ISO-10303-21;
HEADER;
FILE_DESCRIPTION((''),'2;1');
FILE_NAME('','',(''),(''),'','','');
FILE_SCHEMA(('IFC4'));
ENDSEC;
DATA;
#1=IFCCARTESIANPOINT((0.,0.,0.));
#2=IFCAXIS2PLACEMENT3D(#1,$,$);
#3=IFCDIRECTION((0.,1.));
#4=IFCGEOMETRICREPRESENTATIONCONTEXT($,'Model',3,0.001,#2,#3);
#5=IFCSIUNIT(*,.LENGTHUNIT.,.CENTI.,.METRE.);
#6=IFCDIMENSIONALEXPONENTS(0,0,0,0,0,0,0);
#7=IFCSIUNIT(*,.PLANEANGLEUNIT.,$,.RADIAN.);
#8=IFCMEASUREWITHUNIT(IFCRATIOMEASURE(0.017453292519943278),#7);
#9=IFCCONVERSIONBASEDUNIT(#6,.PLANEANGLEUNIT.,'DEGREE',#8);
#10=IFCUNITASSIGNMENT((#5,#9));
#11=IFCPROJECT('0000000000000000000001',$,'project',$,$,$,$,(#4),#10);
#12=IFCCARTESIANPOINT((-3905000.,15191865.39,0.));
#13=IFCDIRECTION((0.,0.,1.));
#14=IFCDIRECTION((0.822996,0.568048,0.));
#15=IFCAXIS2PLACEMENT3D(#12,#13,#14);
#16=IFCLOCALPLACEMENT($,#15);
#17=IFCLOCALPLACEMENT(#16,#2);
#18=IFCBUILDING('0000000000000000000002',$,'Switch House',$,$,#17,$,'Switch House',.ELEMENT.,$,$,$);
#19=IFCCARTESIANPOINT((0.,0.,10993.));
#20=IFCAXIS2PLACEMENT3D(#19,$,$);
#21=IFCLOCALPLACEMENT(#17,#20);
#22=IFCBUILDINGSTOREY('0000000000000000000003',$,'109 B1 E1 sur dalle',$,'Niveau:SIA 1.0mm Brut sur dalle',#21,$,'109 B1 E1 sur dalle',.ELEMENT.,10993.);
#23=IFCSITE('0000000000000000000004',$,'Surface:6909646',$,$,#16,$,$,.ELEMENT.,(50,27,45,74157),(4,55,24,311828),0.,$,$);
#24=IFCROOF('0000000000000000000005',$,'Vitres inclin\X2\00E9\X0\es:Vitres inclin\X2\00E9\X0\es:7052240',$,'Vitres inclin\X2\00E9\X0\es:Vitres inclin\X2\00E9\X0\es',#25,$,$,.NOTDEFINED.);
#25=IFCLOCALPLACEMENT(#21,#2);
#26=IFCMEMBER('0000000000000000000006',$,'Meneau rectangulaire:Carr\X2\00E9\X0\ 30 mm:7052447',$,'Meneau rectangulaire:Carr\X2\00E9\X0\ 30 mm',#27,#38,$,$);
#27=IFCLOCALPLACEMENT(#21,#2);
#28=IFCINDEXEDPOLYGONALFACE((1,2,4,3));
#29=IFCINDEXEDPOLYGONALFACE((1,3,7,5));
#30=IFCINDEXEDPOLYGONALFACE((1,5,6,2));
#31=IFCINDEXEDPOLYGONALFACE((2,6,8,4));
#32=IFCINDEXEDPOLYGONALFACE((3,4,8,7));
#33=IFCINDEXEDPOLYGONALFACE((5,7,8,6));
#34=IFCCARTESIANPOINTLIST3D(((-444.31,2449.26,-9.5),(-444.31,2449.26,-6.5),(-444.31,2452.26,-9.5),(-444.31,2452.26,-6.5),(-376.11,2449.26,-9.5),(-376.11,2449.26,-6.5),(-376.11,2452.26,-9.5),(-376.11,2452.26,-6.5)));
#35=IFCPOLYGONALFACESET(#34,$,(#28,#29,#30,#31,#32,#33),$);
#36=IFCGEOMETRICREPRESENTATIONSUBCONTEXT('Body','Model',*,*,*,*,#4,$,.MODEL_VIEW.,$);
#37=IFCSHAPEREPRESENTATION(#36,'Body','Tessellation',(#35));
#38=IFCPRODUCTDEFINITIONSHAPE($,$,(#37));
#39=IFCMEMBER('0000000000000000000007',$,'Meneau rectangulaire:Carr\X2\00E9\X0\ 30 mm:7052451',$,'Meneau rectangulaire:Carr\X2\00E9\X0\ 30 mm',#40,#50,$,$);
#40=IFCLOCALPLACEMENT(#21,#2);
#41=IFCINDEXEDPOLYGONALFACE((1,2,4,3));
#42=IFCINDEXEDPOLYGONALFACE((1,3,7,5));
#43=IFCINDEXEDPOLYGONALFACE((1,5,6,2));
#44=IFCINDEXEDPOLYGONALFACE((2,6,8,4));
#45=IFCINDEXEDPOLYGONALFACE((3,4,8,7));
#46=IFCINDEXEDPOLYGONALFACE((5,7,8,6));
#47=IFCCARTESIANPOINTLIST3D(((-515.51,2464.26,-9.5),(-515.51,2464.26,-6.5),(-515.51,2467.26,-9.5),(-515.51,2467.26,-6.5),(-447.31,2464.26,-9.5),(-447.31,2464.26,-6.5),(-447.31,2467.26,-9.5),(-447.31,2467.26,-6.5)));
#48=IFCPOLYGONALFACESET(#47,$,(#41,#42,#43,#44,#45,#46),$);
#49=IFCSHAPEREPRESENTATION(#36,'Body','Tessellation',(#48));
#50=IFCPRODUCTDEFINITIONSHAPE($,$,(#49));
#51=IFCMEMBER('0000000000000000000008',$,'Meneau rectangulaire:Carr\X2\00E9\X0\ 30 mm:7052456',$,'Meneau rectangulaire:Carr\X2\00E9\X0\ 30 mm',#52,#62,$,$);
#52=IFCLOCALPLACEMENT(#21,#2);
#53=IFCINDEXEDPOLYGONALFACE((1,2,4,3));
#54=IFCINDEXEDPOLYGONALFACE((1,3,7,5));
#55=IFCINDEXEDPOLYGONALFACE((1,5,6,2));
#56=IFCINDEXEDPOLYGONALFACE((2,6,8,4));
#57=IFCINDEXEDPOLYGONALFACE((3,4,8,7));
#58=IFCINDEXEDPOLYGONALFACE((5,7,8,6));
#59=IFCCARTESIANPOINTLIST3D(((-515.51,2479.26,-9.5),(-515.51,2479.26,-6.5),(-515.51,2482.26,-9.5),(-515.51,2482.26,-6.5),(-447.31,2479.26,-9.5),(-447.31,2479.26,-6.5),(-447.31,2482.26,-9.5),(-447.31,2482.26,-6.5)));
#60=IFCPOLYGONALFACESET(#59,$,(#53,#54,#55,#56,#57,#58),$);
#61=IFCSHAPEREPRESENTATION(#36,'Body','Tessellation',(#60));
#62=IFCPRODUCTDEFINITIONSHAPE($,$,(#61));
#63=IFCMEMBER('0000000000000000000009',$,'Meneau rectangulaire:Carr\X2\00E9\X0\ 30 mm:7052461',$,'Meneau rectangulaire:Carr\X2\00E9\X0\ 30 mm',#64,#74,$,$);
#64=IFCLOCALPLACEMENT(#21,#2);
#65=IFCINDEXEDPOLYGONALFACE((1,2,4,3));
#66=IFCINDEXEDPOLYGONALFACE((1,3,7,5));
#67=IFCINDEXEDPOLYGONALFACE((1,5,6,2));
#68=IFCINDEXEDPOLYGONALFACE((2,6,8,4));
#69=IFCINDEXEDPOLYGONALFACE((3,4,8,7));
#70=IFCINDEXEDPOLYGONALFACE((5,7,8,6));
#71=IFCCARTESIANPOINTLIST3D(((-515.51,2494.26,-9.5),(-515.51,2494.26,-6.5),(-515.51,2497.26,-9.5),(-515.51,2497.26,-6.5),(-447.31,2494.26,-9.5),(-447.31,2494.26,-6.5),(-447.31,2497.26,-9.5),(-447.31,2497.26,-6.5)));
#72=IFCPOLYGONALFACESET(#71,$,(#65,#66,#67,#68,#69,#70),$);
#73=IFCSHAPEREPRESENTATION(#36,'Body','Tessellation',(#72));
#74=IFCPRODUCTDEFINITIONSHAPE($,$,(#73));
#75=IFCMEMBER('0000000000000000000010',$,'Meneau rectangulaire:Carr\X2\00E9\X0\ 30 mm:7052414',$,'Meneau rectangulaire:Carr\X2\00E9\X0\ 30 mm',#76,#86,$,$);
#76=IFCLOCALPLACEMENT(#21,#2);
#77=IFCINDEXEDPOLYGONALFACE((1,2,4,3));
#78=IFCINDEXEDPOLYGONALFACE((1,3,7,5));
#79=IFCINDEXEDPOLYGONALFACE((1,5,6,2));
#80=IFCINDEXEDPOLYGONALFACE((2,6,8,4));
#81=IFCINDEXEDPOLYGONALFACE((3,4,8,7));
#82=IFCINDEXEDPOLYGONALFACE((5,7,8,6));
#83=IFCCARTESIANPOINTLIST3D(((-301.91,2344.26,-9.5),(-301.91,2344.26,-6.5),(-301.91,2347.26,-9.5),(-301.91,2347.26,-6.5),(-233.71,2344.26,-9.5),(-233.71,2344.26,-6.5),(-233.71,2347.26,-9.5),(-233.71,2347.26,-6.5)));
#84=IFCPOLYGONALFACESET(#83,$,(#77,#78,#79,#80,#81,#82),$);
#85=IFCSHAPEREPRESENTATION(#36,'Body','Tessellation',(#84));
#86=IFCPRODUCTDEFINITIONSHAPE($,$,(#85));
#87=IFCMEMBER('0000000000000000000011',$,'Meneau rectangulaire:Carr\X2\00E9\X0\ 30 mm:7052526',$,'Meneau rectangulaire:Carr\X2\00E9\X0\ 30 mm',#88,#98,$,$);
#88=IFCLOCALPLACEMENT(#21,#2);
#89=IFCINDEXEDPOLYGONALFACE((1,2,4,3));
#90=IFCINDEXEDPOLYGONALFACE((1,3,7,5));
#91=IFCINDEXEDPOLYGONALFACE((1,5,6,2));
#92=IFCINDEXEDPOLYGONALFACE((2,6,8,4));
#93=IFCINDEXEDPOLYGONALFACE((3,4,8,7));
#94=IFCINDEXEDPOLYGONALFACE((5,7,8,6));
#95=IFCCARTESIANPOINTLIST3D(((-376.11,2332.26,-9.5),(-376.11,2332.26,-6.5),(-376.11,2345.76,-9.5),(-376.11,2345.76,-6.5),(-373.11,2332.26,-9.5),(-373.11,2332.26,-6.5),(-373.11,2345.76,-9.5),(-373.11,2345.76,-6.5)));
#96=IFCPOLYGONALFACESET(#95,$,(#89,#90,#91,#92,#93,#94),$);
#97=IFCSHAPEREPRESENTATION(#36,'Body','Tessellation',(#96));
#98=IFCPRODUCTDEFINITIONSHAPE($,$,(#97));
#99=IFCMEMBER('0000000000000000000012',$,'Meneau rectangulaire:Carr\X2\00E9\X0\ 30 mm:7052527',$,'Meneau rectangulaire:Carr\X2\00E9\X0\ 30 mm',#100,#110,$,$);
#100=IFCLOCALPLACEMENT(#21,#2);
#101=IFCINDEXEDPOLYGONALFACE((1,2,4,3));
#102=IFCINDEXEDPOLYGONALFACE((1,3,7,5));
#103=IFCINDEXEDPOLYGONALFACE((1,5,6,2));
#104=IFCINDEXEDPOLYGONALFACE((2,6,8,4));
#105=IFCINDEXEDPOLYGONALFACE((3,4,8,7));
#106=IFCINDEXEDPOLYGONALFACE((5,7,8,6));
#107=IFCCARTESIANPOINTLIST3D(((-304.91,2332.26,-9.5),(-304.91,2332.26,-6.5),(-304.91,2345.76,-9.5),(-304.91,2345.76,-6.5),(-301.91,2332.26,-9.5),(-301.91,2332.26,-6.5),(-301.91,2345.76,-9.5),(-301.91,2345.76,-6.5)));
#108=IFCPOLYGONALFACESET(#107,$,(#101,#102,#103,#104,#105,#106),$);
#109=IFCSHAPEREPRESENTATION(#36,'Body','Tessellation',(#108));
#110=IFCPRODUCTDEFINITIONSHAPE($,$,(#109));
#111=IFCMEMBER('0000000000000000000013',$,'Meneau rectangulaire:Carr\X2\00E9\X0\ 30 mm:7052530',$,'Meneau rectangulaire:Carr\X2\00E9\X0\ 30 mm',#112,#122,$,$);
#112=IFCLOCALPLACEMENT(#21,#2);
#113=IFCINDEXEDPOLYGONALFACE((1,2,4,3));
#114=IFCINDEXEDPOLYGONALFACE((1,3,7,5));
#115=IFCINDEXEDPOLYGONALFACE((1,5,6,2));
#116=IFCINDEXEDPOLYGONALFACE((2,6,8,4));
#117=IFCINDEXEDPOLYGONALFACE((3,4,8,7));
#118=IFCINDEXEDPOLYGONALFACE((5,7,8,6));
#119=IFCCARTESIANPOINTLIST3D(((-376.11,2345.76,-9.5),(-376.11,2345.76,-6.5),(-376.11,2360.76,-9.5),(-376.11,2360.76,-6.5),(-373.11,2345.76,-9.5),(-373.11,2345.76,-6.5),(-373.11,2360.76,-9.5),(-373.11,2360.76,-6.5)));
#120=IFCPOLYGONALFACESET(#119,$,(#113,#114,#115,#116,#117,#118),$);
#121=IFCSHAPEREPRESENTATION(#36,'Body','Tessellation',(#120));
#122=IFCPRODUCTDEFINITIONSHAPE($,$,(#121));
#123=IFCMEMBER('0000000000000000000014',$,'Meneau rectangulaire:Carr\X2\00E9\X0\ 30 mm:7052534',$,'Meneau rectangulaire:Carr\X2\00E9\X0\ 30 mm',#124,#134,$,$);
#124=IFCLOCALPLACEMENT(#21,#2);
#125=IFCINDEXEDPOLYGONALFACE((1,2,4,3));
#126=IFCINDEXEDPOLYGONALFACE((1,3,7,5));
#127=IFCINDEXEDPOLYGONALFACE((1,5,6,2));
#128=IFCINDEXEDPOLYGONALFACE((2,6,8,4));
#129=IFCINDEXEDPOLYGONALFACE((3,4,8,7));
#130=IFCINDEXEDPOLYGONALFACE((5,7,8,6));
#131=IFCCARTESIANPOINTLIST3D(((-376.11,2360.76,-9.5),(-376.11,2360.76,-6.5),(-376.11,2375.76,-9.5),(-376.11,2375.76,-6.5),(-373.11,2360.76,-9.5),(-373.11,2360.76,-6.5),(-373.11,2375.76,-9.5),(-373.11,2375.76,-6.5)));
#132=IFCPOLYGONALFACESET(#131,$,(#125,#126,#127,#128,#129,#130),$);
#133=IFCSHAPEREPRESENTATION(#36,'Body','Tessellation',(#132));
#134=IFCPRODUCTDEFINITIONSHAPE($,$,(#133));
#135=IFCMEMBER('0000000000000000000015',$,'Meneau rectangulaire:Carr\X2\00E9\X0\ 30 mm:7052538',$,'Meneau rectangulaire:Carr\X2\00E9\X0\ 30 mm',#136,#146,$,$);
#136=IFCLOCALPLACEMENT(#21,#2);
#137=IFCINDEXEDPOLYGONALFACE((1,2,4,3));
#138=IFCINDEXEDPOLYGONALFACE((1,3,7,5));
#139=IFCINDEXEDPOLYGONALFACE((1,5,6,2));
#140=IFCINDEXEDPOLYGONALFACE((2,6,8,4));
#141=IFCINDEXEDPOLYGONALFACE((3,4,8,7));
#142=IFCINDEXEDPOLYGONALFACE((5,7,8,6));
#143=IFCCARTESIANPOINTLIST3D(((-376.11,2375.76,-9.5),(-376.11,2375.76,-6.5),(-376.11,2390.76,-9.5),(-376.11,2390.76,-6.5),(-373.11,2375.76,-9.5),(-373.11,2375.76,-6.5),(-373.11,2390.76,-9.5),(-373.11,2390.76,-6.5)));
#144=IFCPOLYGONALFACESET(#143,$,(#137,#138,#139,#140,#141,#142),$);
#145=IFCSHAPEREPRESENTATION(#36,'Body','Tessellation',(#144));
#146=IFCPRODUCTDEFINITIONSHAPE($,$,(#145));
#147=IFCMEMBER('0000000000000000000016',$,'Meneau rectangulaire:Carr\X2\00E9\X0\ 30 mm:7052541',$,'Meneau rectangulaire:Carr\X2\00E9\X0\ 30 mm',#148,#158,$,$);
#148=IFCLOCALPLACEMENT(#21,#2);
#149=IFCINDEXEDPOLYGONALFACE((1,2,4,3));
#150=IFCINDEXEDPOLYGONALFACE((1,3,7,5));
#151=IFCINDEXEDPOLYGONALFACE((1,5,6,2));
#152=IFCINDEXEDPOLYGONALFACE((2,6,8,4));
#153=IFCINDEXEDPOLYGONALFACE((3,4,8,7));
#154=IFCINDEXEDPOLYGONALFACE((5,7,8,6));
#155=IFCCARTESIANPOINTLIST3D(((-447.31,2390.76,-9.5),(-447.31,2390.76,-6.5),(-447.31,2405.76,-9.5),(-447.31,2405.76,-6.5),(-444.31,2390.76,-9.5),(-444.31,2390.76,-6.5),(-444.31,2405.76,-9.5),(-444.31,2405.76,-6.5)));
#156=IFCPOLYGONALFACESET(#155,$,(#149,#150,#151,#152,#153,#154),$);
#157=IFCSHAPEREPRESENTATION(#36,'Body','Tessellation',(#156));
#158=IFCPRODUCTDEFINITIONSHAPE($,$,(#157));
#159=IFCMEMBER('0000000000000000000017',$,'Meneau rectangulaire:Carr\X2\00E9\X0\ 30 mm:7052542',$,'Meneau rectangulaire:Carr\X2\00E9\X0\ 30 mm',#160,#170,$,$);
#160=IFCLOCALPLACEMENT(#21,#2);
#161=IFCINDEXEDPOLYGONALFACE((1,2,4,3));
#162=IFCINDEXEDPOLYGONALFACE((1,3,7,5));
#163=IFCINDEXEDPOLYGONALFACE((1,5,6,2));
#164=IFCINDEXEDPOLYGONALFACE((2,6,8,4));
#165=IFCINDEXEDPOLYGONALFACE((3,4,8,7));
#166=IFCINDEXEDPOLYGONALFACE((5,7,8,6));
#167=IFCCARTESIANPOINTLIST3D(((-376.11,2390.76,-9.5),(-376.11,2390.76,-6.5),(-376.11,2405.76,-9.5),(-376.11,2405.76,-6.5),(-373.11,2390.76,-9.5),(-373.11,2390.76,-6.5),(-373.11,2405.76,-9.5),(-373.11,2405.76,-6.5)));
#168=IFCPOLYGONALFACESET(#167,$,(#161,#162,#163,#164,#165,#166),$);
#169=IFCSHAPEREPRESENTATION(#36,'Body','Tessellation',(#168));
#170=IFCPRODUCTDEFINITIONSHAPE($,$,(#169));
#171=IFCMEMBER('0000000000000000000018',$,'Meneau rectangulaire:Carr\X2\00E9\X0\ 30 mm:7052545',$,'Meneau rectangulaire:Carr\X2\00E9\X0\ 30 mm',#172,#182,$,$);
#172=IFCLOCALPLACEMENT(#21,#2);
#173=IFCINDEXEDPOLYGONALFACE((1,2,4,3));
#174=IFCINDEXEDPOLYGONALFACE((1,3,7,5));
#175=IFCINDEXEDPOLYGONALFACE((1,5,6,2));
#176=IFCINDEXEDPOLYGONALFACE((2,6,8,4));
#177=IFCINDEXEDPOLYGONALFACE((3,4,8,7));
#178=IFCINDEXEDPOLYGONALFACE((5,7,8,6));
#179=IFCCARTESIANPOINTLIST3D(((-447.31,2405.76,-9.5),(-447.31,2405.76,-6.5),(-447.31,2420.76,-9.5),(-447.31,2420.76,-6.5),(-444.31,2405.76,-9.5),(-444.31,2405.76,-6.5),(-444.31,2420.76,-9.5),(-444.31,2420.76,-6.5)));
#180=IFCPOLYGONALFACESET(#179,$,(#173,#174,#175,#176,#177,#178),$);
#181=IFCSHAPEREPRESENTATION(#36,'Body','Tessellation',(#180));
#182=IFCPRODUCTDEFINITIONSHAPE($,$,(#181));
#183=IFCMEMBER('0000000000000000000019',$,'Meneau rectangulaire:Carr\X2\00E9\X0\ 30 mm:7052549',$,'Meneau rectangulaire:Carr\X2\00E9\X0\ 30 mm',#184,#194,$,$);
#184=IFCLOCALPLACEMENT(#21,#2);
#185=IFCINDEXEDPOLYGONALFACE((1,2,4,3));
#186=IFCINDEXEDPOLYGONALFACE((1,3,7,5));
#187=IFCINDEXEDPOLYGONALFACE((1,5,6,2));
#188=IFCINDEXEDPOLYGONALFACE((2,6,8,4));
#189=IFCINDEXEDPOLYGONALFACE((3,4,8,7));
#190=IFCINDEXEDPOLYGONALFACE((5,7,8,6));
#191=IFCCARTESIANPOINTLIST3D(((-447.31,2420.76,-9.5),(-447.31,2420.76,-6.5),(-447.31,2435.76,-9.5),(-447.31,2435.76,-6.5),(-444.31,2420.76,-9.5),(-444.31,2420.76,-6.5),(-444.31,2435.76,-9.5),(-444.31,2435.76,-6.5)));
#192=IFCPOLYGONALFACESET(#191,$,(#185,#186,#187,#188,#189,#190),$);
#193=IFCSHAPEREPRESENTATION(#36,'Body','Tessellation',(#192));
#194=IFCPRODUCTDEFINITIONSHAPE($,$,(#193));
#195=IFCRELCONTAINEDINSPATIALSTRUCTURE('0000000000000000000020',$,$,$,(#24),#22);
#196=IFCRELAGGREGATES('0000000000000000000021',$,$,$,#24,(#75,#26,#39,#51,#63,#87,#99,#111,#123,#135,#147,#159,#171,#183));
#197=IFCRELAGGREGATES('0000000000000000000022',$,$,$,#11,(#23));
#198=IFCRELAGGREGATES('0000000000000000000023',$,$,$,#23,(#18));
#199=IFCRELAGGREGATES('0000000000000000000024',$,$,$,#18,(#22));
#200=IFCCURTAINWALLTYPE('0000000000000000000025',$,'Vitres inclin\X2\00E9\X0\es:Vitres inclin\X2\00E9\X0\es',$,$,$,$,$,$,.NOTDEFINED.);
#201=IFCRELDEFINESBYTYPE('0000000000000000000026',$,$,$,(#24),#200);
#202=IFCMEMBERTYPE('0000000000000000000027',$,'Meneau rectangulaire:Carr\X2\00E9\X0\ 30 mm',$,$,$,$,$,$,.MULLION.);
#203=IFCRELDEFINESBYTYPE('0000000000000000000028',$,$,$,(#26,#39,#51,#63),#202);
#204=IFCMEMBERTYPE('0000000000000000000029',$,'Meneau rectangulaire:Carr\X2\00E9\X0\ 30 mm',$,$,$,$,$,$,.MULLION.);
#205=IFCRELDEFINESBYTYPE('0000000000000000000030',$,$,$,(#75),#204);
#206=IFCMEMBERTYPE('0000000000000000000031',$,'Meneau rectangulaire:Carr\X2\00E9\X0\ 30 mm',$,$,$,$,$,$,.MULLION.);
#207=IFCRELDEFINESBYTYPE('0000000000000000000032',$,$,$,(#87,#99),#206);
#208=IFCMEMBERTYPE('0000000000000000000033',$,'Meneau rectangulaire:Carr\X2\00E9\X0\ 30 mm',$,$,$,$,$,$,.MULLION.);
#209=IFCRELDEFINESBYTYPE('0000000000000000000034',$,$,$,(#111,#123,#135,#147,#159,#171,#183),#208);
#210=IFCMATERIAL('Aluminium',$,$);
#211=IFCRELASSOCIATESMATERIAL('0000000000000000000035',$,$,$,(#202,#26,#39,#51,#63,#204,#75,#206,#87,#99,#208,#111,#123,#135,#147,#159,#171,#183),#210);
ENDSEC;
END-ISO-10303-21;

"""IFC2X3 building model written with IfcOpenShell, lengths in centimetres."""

from ifc_helpers import new_model, entity, si_unit, converted_unit, direction, frame, origin, origin_2d_with_axis, place, context, subcontext, project, spatial, rectangle, extrude, source, transform, mapped, material, type_object, type_shapes, element, aggregate, save


model = new_model("IFC2X3")

# Units and contexts
model_context = context("Model", 3, precision=0.001, world=origin(), true_north=direction((0.0, 1.0)))
body_context = subcontext(model_context, "Body", "Model", "MODEL_VIEW")
ifc_project = project(units=[si_unit("LENGTHUNIT", "METRE", prefix="CENTI"), converted_unit("PLANEANGLEUNIT", "DEGREE", entity("IfcRatioMeasure", 0.017453292519943278), si_unit("PLANEANGLEUNIT", "RADIAN"), dimensions=[0, 0, 0, 0, 0, 0, 0])], contexts=[model_context])

# Site, building, storey
site_placement = place(None, frame((-3905000.0, 15191865.39, 0.0), z_axis=(0.0, 0.0, 1.0), x_axis=(0.822996, 0.568048, 0.0)))
site = spatial("IfcSite", under=ifc_project, at=site_placement, Name="Surface:6909646", CompositionType="ELEMENT", RefLatitude=(50, 27, 45, 74157), RefLongitude=(4, 55, 24, 311828), RefElevation=0.0)
building_placement = place(site_placement, origin())
building = spatial("IfcBuilding", under=site, at=building_placement, Name="Switch House", LongName="Switch House", CompositionType="ELEMENT")
storey_placement = place(building_placement, frame((0.0, 0.0, 10993.0)))
storey = spatial("IfcBuildingStorey", under=building, at=storey_placement, Name="109 B1 E1 sur dalle", ObjectType="Niveau:SIA 1.0mm Brut sur dalle", LongName="109 B1 E1 sur dalle", CompositionType="ELEMENT", Elevation=10993.0)

# Roof, members
curtain_wall_type = type_object("IfcCurtainWallType", Name="Vitres inclinées:Vitres inclinées", PredefinedType="NOTDEFINED")
roof_placement = place(storey_placement, frame((0.0, 0.0, -10993.0)))
roof = element("IfcRoof", 1, at=roof_placement, inside=storey, type_object=curtain_wall_type, Name="Vitres inclinées:Vitres inclinées:7052240", ObjectType="Vitres inclinées:Vitres inclinées", ShapeType="NOTDEFINED")
ifc_material = material(Name="Aluminium")
member_type_1 = type_object("IfcMemberType", Name="Meneau rectangulaire:Carré 30 mm", PredefinedType="MULLION", material=ifc_material)
shared_shape_1 = source(origin(), body_context, "Body", "SweptSolid", [
    extrude(rectangle(XDim=3.0, YDim=3.0, at=origin_2d_with_axis()), frame((0.0, 0.0, -68.2), z_axis=(0.0, 0.0, 1.0), x_axis=(0.0, -1.0, 0.0)), (0.0, 0.0, 1.0), 68.2),
])
type_shapes(member_type_1, [shared_shape_1])
member_1_placement = place(roof_placement, frame((-444.31, 2450.76, 10985.0), z_axis=(-1.0, 0.0, 0.0), x_axis=(0.0, 1.0, 0.0)))
member_1 = element("IfcMember", 2, at=member_1_placement, type_object=member_type_1, material=ifc_material, Name="Meneau rectangulaire:Carré 30 mm:7052447", ObjectType="Meneau rectangulaire:Carré 30 mm", context=body_context, shape_type="MappedRepresentation", body=[
    mapped(shared_shape_1, transform((0.0, 0.0, 0.0), scale=1.0)),
])
member_2_placement = place(roof_placement, frame((-515.51, 2465.76, 10985.0), z_axis=(-1.0, 0.0, 0.0), x_axis=(0.0, 1.0, 0.0)))
member_2 = element("IfcMember", 3, at=member_2_placement, type_object=member_type_1, material=ifc_material, Name="Meneau rectangulaire:Carré 30 mm:7052451", ObjectType="Meneau rectangulaire:Carré 30 mm", context=body_context, shape_type="MappedRepresentation", body=[
    mapped(shared_shape_1, transform((0.0, 0.0, 0.0), scale=1.0)),
])
member_3_placement = place(roof_placement, frame((-515.51, 2480.76, 10985.0), z_axis=(-1.0, 0.0, 0.0), x_axis=(0.0, 1.0, 0.0)))
member_3 = element("IfcMember", 4, at=member_3_placement, type_object=member_type_1, material=ifc_material, Name="Meneau rectangulaire:Carré 30 mm:7052456", ObjectType="Meneau rectangulaire:Carré 30 mm", context=body_context, shape_type="MappedRepresentation", body=[
    mapped(shared_shape_1, transform((0.0, 0.0, 0.0), scale=1.0)),
])
member_4_placement = place(roof_placement, frame((-515.51, 2495.76, 10985.0), z_axis=(-1.0, 0.0, 0.0), x_axis=(0.0, 1.0, 0.0)))
member_4 = element("IfcMember", 5, at=member_4_placement, type_object=member_type_1, material=ifc_material, Name="Meneau rectangulaire:Carré 30 mm:7052461", ObjectType="Meneau rectangulaire:Carré 30 mm", context=body_context, shape_type="MappedRepresentation", body=[
    mapped(shared_shape_1, transform((0.0, 0.0, 0.0), scale=1.0)),
])
member_type_2 = type_object("IfcMemberType", Name="Meneau rectangulaire:Carré 30 mm", PredefinedType="MULLION", material=ifc_material)
shared_shape_2 = source(origin(), body_context, "Body", "SweptSolid", [
    extrude(rectangle(XDim=3.0, YDim=3.0, at=origin_2d_with_axis()), frame((0.0, 0.0, -68.2), z_axis=(0.0, 0.0, 1.0), x_axis=(0.0, -1.0, 0.0)), (0.0, 0.0, 1.0), 68.2),
])
type_shapes(member_type_2, [shared_shape_2])
member_5_placement = place(roof_placement, frame((-301.91, 2345.76, 10985.0), z_axis=(-1.0, 0.0, 0.0), x_axis=(0.0, 1.0, 0.0)))
member_5 = element("IfcMember", 6, at=member_5_placement, type_object=member_type_2, material=ifc_material, Name="Meneau rectangulaire:Carré 30 mm:7052414", ObjectType="Meneau rectangulaire:Carré 30 mm", context=body_context, shape_type="MappedRepresentation", body=[
    mapped(shared_shape_2, transform((0.0, 0.0, 0.0), scale=1.0)),
])
member_type_3 = type_object("IfcMemberType", Name="Meneau rectangulaire:Carré 30 mm", PredefinedType="MULLION", material=ifc_material)
shared_shape_3 = source(origin(), body_context, "Body", "SweptSolid", [
    extrude(rectangle(XDim=3.0, YDim=3.0, at=origin_2d_with_axis()), frame((0.0, 0.0, -13.5), z_axis=(0.0, 0.0, 1.0), x_axis=(0.0, -1.0, 0.0)), (0.0, 0.0, 1.0), 13.5),
])
type_shapes(member_type_3, [shared_shape_3])
member_6_placement = place(roof_placement, frame((-374.61, 2345.76, 10985.0), z_axis=(0.0, 1.0, 0.0), x_axis=(1.0, 0.0, 0.0)))
member_6 = element("IfcMember", 7, at=member_6_placement, type_object=member_type_3, material=ifc_material, Name="Meneau rectangulaire:Carré 30 mm:7052526", ObjectType="Meneau rectangulaire:Carré 30 mm", context=body_context, shape_type="MappedRepresentation", body=[
    mapped(shared_shape_3, transform((0.0, 0.0, 0.0), scale=1.0)),
])
member_7_placement = place(roof_placement, frame((-303.41, 2345.76, 10985.0), z_axis=(0.0, 1.0, 0.0), x_axis=(1.0, 0.0, 0.0)))
member_7 = element("IfcMember", 8, at=member_7_placement, type_object=member_type_3, material=ifc_material, Name="Meneau rectangulaire:Carré 30 mm:7052527", ObjectType="Meneau rectangulaire:Carré 30 mm", context=body_context, shape_type="MappedRepresentation", body=[
    mapped(shared_shape_3, transform((0.0, 0.0, 0.0), scale=1.0)),
])
member_type_4 = type_object("IfcMemberType", Name="Meneau rectangulaire:Carré 30 mm", PredefinedType="MULLION", material=ifc_material)
shared_shape_4 = source(origin(), body_context, "Body", "SweptSolid", [
    extrude(rectangle(XDim=3.0, YDim=3.0, at=origin_2d_with_axis()), frame((0.0, 0.0, -15.0), z_axis=(0.0, 0.0, 1.0), x_axis=(0.0, -1.0, 0.0)), (0.0, 0.0, 1.0), 15.0),
])
type_shapes(member_type_4, [shared_shape_4])
member_8_placement = place(roof_placement, frame((-374.61, 2360.76, 10985.0), z_axis=(0.0, 1.0, 0.0), x_axis=(1.0, 0.0, 0.0)))
member_8 = element("IfcMember", 9, at=member_8_placement, type_object=member_type_4, material=ifc_material, Name="Meneau rectangulaire:Carré 30 mm:7052530", ObjectType="Meneau rectangulaire:Carré 30 mm", context=body_context, shape_type="MappedRepresentation", body=[
    mapped(shared_shape_4, transform((0.0, 0.0, 0.0), scale=1.0)),
])
member_9_placement = place(roof_placement, frame((-374.61, 2375.76, 10985.0), z_axis=(0.0, 1.0, 0.0), x_axis=(1.0, 0.0, 0.0)))
member_9 = element("IfcMember", 10, at=member_9_placement, type_object=member_type_4, material=ifc_material, Name="Meneau rectangulaire:Carré 30 mm:7052534", ObjectType="Meneau rectangulaire:Carré 30 mm", context=body_context, shape_type="MappedRepresentation", body=[
    mapped(shared_shape_4, transform((0.0, 0.0, 0.0), scale=1.0)),
])
member_10_placement = place(roof_placement, frame((-374.61, 2390.76, 10985.0), z_axis=(0.0, 1.0, 0.0), x_axis=(1.0, 0.0, 0.0)))
member_10 = element("IfcMember", 11, at=member_10_placement, type_object=member_type_4, material=ifc_material, Name="Meneau rectangulaire:Carré 30 mm:7052538", ObjectType="Meneau rectangulaire:Carré 30 mm", context=body_context, shape_type="MappedRepresentation", body=[
    mapped(shared_shape_4, transform((0.0, 0.0, 0.0), scale=1.0)),
])
member_11_placement = place(roof_placement, frame((-445.81, 2405.76, 10985.0), z_axis=(0.0, 1.0, 0.0), x_axis=(1.0, 0.0, 0.0)))
member_11 = element("IfcMember", 12, at=member_11_placement, type_object=member_type_4, material=ifc_material, Name="Meneau rectangulaire:Carré 30 mm:7052541", ObjectType="Meneau rectangulaire:Carré 30 mm", context=body_context, shape_type="MappedRepresentation", body=[
    mapped(shared_shape_4, transform((0.0, 0.0, 0.0), scale=1.0)),
])
member_12_placement = place(roof_placement, frame((-374.61, 2405.76, 10985.0), z_axis=(0.0, 1.0, 0.0), x_axis=(1.0, 0.0, 0.0)))
member_12 = element("IfcMember", 13, at=member_12_placement, type_object=member_type_4, material=ifc_material, Name="Meneau rectangulaire:Carré 30 mm:7052542", ObjectType="Meneau rectangulaire:Carré 30 mm", context=body_context, shape_type="MappedRepresentation", body=[
    mapped(shared_shape_4, transform((0.0, 0.0, 0.0), scale=1.0)),
])
member_13_placement = place(roof_placement, frame((-445.81, 2420.76, 10985.0), z_axis=(0.0, 1.0, 0.0), x_axis=(1.0, 0.0, 0.0)))
member_13 = element("IfcMember", 14, at=member_13_placement, type_object=member_type_4, material=ifc_material, Name="Meneau rectangulaire:Carré 30 mm:7052545", ObjectType="Meneau rectangulaire:Carré 30 mm", context=body_context, shape_type="MappedRepresentation", body=[
    mapped(shared_shape_4, transform((0.0, 0.0, 0.0), scale=1.0)),
])
member_14_placement = place(roof_placement, frame((-445.81, 2435.76, 10985.0), z_axis=(0.0, 1.0, 0.0), x_axis=(1.0, 0.0, 0.0)))
member_14 = element("IfcMember", 15, at=member_14_placement, type_object=member_type_4, material=ifc_material, Name="Meneau rectangulaire:Carré 30 mm:7052549", ObjectType="Meneau rectangulaire:Carré 30 mm", context=body_context, shape_type="MappedRepresentation", body=[
    mapped(shared_shape_4, transform((0.0, 0.0, 0.0), scale=1.0)),
])
aggregate(roof, [member_5, member_1, member_2, member_3, member_4, member_6, member_7, member_8, member_9, member_10, member_11, member_12, member_13, member_14])

save(model, "model.ifc")
